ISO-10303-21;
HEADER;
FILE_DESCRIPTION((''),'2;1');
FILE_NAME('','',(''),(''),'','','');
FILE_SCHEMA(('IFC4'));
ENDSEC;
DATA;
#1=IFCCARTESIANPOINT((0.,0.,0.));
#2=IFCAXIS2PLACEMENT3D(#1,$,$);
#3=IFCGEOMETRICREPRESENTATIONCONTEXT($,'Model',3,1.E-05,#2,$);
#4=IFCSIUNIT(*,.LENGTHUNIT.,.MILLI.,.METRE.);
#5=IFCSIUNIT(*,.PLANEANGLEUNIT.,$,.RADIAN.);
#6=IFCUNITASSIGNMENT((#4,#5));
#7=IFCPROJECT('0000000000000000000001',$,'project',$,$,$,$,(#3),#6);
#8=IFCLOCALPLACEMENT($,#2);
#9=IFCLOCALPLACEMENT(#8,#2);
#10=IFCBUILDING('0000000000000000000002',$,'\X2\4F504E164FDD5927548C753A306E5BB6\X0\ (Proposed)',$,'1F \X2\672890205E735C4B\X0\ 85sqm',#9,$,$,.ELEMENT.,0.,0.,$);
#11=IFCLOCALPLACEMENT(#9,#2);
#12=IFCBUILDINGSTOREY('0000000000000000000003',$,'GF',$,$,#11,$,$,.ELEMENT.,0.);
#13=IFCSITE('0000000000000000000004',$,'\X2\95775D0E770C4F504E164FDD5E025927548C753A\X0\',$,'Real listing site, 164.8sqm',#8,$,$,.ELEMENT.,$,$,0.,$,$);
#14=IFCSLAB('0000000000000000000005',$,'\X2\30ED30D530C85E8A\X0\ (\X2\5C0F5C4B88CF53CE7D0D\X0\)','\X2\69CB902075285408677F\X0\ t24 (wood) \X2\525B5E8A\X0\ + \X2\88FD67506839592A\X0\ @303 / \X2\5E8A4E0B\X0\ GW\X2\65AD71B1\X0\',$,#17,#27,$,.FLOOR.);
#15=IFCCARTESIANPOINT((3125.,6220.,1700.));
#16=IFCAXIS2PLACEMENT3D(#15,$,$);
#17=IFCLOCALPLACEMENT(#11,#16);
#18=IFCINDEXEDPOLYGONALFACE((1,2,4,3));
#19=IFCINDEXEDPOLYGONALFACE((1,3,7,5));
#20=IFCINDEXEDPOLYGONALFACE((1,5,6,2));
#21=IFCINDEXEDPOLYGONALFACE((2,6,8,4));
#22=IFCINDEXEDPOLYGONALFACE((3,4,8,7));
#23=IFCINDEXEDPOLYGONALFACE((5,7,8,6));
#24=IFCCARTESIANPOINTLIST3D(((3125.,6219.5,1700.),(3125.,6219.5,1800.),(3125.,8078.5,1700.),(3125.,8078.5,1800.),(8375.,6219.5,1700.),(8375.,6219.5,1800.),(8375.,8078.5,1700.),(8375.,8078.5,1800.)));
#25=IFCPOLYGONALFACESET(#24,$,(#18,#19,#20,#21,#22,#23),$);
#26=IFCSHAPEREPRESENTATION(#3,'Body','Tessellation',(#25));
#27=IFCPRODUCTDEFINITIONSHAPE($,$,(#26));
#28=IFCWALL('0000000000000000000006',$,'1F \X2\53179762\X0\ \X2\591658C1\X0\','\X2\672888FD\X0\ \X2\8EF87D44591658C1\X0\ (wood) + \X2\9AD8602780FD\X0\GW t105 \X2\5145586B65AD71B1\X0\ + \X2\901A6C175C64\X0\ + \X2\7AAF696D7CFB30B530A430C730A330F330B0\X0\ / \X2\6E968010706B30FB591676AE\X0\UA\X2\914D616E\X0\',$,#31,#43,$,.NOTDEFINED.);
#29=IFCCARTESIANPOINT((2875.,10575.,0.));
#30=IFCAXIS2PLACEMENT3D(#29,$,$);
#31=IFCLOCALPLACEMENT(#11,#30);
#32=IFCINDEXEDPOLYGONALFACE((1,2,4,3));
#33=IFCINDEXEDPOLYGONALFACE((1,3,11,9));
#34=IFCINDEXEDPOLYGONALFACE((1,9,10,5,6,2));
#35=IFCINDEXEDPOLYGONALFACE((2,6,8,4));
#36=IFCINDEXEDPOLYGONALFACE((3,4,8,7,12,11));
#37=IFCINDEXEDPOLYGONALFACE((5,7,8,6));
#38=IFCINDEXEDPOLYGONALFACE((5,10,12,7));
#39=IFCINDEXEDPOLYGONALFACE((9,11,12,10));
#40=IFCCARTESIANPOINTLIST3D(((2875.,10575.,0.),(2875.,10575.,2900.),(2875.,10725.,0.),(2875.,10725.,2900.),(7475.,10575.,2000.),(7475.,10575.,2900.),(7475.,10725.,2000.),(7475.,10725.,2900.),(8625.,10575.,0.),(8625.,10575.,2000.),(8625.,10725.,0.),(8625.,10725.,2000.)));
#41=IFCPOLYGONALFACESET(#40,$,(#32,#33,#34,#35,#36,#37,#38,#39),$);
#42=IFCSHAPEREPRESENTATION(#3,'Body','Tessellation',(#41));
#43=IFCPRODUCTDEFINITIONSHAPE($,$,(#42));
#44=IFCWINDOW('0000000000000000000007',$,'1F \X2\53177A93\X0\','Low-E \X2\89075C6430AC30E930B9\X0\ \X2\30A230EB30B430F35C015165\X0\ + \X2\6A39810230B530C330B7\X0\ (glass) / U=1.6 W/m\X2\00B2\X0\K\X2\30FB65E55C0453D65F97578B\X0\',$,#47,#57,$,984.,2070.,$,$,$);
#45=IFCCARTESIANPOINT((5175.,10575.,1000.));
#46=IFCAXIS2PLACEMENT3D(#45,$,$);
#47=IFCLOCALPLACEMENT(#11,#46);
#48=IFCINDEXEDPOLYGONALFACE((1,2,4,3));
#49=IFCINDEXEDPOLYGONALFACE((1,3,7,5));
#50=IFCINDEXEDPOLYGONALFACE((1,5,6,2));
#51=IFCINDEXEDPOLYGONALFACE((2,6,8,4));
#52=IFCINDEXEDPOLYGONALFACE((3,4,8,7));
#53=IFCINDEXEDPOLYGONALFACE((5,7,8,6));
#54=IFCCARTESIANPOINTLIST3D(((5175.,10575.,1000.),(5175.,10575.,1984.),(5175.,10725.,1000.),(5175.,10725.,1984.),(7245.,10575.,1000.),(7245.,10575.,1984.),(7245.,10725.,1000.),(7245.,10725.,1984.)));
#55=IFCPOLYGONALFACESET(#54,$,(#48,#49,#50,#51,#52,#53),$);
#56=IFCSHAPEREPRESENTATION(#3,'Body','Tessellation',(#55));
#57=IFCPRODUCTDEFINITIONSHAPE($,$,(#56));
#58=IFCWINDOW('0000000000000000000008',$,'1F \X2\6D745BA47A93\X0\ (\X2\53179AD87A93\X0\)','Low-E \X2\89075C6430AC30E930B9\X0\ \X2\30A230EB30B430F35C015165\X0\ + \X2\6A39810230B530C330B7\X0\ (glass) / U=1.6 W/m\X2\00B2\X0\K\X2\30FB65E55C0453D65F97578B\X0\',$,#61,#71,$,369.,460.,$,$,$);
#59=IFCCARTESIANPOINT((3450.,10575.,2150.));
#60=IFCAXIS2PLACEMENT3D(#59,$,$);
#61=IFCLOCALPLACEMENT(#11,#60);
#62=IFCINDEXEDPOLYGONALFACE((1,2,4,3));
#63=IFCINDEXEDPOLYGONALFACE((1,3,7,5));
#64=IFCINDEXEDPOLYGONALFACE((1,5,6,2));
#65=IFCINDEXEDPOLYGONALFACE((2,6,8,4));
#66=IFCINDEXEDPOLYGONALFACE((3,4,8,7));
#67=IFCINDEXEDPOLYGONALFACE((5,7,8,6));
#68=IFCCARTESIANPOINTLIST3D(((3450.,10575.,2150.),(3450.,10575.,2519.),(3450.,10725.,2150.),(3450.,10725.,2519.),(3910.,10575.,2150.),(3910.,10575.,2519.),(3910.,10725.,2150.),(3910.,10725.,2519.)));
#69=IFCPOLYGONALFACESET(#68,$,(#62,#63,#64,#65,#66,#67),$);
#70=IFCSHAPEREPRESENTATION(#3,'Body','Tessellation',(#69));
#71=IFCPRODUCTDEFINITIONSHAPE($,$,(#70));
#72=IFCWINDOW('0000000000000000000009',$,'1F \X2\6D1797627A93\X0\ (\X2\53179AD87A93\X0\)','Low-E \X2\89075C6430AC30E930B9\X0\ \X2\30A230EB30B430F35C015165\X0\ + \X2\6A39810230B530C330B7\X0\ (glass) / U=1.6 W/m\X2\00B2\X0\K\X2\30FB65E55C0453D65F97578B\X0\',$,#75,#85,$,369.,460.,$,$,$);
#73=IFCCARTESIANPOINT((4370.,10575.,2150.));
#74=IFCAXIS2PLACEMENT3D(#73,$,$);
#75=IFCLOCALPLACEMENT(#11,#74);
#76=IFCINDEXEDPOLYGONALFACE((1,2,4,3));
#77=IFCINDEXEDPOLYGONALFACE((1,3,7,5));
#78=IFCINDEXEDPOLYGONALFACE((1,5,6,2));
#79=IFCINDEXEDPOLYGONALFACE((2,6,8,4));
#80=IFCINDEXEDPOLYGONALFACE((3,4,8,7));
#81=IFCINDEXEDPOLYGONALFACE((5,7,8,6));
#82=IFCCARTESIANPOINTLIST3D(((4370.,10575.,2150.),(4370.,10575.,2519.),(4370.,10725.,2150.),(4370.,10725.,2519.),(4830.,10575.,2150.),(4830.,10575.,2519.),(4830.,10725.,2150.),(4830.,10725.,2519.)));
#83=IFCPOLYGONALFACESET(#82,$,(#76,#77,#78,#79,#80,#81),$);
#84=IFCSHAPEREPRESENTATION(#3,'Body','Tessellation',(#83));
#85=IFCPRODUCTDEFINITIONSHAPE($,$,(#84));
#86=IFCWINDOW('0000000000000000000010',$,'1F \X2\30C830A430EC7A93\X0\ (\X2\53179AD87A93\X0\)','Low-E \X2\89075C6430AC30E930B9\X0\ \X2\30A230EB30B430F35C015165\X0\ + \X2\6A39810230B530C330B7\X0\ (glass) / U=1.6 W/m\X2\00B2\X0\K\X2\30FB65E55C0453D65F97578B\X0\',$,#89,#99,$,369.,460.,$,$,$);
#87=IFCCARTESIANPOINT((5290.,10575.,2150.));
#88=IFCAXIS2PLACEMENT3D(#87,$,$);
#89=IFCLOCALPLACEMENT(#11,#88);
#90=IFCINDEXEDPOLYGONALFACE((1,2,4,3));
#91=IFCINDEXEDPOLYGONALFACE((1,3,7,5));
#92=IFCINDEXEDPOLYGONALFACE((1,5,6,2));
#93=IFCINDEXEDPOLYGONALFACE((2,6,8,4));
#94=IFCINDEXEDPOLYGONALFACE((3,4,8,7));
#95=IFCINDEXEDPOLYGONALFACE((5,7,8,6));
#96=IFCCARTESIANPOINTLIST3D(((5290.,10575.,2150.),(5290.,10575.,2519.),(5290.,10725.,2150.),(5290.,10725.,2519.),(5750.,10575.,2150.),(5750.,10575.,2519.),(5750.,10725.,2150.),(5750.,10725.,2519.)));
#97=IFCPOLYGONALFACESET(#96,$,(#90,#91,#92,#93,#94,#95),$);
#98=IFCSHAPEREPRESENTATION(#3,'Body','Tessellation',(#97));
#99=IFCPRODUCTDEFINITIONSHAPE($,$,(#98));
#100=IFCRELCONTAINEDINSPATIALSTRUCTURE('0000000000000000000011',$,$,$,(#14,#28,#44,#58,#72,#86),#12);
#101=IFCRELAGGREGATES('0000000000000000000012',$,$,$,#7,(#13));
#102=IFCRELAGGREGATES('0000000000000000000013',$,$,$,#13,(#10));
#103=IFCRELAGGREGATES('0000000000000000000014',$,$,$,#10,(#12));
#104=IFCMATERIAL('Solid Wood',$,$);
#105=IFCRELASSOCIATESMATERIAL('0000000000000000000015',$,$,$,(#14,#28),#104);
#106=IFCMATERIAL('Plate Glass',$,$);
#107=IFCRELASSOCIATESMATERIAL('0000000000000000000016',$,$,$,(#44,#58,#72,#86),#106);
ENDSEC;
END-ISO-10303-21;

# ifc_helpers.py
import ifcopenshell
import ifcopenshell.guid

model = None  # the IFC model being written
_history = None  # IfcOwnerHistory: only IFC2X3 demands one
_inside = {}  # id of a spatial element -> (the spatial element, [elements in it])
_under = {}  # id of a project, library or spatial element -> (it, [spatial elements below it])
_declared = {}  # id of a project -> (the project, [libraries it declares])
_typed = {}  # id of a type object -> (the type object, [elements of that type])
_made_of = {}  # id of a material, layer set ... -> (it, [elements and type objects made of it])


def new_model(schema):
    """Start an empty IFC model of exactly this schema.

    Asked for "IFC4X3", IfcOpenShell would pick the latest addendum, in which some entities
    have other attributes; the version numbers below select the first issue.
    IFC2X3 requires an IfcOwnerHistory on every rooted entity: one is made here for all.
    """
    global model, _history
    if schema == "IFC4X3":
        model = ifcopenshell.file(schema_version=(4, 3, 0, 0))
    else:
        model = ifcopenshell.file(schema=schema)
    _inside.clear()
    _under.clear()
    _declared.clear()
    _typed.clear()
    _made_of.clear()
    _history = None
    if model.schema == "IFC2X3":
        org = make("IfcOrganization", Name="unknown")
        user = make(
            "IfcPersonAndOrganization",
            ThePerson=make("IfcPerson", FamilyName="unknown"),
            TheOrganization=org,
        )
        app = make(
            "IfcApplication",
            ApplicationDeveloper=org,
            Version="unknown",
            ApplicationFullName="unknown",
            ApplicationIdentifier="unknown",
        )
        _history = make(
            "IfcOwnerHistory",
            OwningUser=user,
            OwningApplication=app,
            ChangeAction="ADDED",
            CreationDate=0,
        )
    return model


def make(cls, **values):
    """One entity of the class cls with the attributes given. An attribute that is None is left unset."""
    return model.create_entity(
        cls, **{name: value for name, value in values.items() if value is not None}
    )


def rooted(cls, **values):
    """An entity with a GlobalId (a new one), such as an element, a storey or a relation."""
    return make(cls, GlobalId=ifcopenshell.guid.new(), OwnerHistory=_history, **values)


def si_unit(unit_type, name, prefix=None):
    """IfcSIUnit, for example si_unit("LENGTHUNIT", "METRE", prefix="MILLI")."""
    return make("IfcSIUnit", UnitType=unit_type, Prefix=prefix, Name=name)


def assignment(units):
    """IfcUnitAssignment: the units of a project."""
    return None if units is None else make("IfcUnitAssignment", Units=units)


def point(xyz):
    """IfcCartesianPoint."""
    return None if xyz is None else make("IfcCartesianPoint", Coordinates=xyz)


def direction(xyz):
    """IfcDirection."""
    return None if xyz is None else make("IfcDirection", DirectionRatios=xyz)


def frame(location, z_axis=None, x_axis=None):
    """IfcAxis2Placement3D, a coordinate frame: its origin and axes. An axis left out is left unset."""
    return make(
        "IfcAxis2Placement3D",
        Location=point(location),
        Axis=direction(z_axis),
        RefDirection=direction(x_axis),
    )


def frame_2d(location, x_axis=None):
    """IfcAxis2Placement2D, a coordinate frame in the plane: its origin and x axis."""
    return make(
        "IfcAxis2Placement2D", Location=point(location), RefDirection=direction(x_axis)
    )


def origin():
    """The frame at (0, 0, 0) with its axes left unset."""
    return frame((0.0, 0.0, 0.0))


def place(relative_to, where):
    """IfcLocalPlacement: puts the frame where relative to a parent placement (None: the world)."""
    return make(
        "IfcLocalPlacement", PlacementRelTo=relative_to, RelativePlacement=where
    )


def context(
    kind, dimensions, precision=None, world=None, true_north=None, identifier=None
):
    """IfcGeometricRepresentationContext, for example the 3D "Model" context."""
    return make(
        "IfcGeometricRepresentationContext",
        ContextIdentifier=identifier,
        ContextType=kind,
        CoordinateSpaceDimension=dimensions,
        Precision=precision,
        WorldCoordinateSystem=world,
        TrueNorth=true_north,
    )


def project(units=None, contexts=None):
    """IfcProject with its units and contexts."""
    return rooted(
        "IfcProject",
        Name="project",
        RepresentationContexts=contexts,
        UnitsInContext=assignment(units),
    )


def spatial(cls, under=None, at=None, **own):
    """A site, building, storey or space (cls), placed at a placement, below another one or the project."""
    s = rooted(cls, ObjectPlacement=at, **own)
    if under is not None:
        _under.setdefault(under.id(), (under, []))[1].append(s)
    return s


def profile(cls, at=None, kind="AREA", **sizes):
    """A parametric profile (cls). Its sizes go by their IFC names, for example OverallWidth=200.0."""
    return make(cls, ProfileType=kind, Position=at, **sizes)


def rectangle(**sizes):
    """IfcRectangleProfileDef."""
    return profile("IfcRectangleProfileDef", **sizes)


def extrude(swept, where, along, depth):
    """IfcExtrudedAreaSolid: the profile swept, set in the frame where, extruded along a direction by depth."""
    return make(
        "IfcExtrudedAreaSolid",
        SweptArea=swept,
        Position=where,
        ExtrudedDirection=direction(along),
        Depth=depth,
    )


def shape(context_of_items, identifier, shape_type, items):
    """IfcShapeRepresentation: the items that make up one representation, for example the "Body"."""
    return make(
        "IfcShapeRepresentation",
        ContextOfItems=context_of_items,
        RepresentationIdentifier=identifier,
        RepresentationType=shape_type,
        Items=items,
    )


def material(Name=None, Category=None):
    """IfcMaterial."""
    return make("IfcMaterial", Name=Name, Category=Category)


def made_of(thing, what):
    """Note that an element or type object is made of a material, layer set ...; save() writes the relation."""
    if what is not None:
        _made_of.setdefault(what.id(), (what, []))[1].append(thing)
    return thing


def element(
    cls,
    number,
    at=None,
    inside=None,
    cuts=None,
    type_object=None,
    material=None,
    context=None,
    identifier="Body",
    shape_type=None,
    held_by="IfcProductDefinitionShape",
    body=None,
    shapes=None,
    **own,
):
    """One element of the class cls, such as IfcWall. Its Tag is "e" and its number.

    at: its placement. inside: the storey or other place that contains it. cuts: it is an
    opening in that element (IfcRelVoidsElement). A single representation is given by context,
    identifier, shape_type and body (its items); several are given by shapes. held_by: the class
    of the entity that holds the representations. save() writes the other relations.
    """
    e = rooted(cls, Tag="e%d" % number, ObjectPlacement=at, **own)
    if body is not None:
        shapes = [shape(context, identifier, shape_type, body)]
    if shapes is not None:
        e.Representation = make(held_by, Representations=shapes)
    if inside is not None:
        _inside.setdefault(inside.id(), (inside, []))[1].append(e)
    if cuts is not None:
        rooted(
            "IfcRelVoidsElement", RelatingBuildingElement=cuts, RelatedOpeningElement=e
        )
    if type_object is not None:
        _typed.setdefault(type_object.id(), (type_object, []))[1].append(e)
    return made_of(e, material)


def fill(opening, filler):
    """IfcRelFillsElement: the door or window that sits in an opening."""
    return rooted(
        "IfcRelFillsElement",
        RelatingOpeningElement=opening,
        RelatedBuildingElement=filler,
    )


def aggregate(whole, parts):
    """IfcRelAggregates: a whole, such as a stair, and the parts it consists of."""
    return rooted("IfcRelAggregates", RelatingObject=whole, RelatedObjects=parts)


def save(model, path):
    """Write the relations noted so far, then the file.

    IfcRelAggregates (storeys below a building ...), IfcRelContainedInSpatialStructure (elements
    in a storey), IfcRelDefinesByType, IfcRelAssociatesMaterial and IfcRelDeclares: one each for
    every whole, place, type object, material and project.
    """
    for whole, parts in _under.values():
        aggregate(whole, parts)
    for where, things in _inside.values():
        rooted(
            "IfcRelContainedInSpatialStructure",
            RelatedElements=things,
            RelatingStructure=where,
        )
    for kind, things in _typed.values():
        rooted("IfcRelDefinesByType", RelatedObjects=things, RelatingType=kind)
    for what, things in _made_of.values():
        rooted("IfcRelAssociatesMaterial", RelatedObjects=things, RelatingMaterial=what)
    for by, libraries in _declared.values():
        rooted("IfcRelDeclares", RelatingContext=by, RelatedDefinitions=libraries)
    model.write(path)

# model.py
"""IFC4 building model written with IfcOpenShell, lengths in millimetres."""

from ifc_helpers import new_model, si_unit, frame, frame_2d, origin, place, context, project, spatial, rectangle, extrude, material, element, fill, save


model = new_model("IFC4")

# Units and contexts
model_context = context("Model", 3, precision=1e-05, world=origin())
ifc_project = project(units=[si_unit("LENGTHUNIT", "METRE", prefix="MILLI"), si_unit("PLANEANGLEUNIT", "RADIAN")], contexts=[model_context])

# Site, building, storey
site_placement = place(None, origin())
site = spatial("IfcSite", under=ifc_project, at=site_placement, Name="長崎県佐世保市大和町", ObjectType="Real listing site, 164.8sqm", CompositionType="ELEMENT", RefElevation=0.0)
building_placement = place(site_placement, origin())
building = spatial("IfcBuilding", under=site, at=building_placement, Name="佐世保大和町の家 (Proposed)", ObjectType="1F 木造平屋 85sqm", CompositionType="ELEMENT", ElevationOfRefHeight=0.0, ElevationOfTerrain=0.0)
storey_placement = place(building_placement, origin())
storey = spatial("IfcBuildingStorey", under=building, at=storey_placement, Name="GF", CompositionType="ELEMENT", Elevation=0.0)

# Slab
ifc_material_1 = material(Name="Solid Wood")
slab_placement = place(storey_placement, frame((3125.0, 6220.0, 1700.0)))
element("IfcSlab", 1, at=slab_placement, inside=storey, material=ifc_material_1, Name="ロフト床 (小屋裏収納)", Description="構造用合板 t24 (wood) 剛床 + 製材根太 @303 / 床下 GW断熱", PredefinedType="FLOOR", context=model_context, shape_type="SweptSolid", body=[
    extrude(rectangle(XDim=5250.0, YDim=1859.0, at=frame_2d((2625.0, 929.0))), frame((3125.0, 6220.0, 1700.0)), (0.0, 0.0, 1.0), 100.0),
])

# Wall, openings, windows
wall_1_placement = place(storey_placement, frame((2875.0, 10575.0, 0.0)))
wall_1 = element("IfcWall", 2, at=wall_1_placement, inside=storey, material=ifc_material_1, Name="1F 北面 外壁", Description="木製 軸組外壁 (wood) + 高性能GW t105 充填断熱 + 通気層 + 窯業系サイディング / 準耐火・外皮UA配慮", PredefinedType="NOTDEFINED", context=model_context, shape_type="SweptSolid", body=[
    extrude(rectangle(XDim=5750.0, YDim=150.0, at=frame_2d((2875.0, 75.0))), frame((2875.0, 10575.0, 0.0)), (0.0, 0.0, 1.0), 2900.0),
])
opening_1_placement = place(storey_placement, frame((5175.0, 10575.0, 1000.0)))
opening_1 = element("IfcOpeningElement", 3, at=opening_1_placement, cuts=wall_1, PredefinedType="NOTDEFINED", context=model_context, shape_type="SweptSolid", body=[
    extrude(rectangle(XDim=2070.0, YDim=150.0, at=frame_2d((1035.0, 75.0))), frame((5175.0, 10575.0, 1000.0)), (0.0, 0.0, 1.0), 984.0),
])
opening_2_placement = place(storey_placement, frame((3450.0, 10575.0, 2150.0)))
opening_2 = element("IfcOpeningElement", 4, at=opening_2_placement, cuts=wall_1, PredefinedType="NOTDEFINED", context=model_context, shape_type="SweptSolid", body=[
    extrude(rectangle(XDim=460.0, YDim=150.0, at=frame_2d((230.0, 75.0))), frame((3450.0, 10575.0, 2150.0)), (0.0, 0.0, 1.0), 369.0),
])
opening_3_placement = place(storey_placement, frame((4370.0, 10575.0, 2150.0)))
opening_3 = element("IfcOpeningElement", 5, at=opening_3_placement, cuts=wall_1, PredefinedType="NOTDEFINED", context=model_context, shape_type="SweptSolid", body=[
    extrude(rectangle(XDim=460.0, YDim=150.0, at=frame_2d((230.0, 75.0))), frame((4370.0, 10575.0, 2150.0)), (0.0, 0.0, 1.0), 369.0),
])
opening_4_placement = place(storey_placement, frame((5290.0, 10575.0, 2150.0)))
opening_4 = element("IfcOpeningElement", 6, at=opening_4_placement, cuts=wall_1, PredefinedType="NOTDEFINED", context=model_context, shape_type="SweptSolid", body=[
    extrude(rectangle(XDim=460.0, YDim=150.0, at=frame_2d((230.0, 75.0))), frame((5290.0, 10575.0, 2150.0)), (0.0, 0.0, 1.0), 369.0),
])
ifc_material_2 = material(Name="Plate Glass")
window_1_placement = place(storey_placement, frame((5175.0, 10575.0, 1000.0)))
window_1 = element("IfcWindow", 7, at=window_1_placement, inside=storey, material=ifc_material_2, Name="1F 北窓", Description="Low-E 複層ガラス アルゴン封入 + 樹脂サッシ (glass) / U=1.6 W/m²K・日射取得型", OverallHeight=984.0, OverallWidth=2070.0, context=model_context, shape_type="SweptSolid", body=[
    extrude(rectangle(XDim=2070.0, YDim=150.0, at=frame_2d((1035.0, 75.0))), frame((5175.0, 10575.0, 1000.0)), (0.0, 0.0, 1.0), 984.0),
])
fill(opening_1, window_1)
window_2_placement = place(storey_placement, frame((3450.0, 10575.0, 2150.0)))
window_2 = element("IfcWindow", 8, at=window_2_placement, inside=storey, material=ifc_material_2, Name="1F 浴室窓 (北高窓)", Description="Low-E 複層ガラス アルゴン封入 + 樹脂サッシ (glass) / U=1.6 W/m²K・日射取得型", OverallHeight=369.0, OverallWidth=460.0, context=model_context, shape_type="SweptSolid", body=[
    extrude(rectangle(XDim=460.0, YDim=150.0, at=frame_2d((230.0, 75.0))), frame((3450.0, 10575.0, 2150.0)), (0.0, 0.0, 1.0), 369.0),
])
fill(opening_2, window_2)
window_3_placement = place(storey_placement, frame((4370.0, 10575.0, 2150.0)))
window_3 = element("IfcWindow", 9, at=window_3_placement, inside=storey, material=ifc_material_2, Name="1F 洗面窓 (北高窓)", Description="Low-E 複層ガラス アルゴン封入 + 樹脂サッシ (glass) / U=1.6 W/m²K・日射取得型", OverallHeight=369.0, OverallWidth=460.0, context=model_context, shape_type="SweptSolid", body=[
    extrude(rectangle(XDim=460.0, YDim=150.0, at=frame_2d((230.0, 75.0))), frame((4370.0, 10575.0, 2150.0)), (0.0, 0.0, 1.0), 369.0),
])
fill(opening_3, window_3)
window_4_placement = place(storey_placement, frame((5290.0, 10575.0, 2150.0)))
window_4 = element("IfcWindow", 10, at=window_4_placement, inside=storey, material=ifc_material_2, Name="1F トイレ窓 (北高窓)", Description="Low-E 複層ガラス アルゴン封入 + 樹脂サッシ (glass) / U=1.6 W/m²K・日射取得型", OverallHeight=369.0, OverallWidth=460.0, context=model_context, shape_type="SweptSolid", body=[
    extrude(rectangle(XDim=460.0, YDim=150.0, at=frame_2d((230.0, 75.0))), frame((5290.0, 10575.0, 2150.0)), (0.0, 0.0, 1.0), 369.0),
])
fill(opening_4, window_4)

save(model, "model.ifc")
